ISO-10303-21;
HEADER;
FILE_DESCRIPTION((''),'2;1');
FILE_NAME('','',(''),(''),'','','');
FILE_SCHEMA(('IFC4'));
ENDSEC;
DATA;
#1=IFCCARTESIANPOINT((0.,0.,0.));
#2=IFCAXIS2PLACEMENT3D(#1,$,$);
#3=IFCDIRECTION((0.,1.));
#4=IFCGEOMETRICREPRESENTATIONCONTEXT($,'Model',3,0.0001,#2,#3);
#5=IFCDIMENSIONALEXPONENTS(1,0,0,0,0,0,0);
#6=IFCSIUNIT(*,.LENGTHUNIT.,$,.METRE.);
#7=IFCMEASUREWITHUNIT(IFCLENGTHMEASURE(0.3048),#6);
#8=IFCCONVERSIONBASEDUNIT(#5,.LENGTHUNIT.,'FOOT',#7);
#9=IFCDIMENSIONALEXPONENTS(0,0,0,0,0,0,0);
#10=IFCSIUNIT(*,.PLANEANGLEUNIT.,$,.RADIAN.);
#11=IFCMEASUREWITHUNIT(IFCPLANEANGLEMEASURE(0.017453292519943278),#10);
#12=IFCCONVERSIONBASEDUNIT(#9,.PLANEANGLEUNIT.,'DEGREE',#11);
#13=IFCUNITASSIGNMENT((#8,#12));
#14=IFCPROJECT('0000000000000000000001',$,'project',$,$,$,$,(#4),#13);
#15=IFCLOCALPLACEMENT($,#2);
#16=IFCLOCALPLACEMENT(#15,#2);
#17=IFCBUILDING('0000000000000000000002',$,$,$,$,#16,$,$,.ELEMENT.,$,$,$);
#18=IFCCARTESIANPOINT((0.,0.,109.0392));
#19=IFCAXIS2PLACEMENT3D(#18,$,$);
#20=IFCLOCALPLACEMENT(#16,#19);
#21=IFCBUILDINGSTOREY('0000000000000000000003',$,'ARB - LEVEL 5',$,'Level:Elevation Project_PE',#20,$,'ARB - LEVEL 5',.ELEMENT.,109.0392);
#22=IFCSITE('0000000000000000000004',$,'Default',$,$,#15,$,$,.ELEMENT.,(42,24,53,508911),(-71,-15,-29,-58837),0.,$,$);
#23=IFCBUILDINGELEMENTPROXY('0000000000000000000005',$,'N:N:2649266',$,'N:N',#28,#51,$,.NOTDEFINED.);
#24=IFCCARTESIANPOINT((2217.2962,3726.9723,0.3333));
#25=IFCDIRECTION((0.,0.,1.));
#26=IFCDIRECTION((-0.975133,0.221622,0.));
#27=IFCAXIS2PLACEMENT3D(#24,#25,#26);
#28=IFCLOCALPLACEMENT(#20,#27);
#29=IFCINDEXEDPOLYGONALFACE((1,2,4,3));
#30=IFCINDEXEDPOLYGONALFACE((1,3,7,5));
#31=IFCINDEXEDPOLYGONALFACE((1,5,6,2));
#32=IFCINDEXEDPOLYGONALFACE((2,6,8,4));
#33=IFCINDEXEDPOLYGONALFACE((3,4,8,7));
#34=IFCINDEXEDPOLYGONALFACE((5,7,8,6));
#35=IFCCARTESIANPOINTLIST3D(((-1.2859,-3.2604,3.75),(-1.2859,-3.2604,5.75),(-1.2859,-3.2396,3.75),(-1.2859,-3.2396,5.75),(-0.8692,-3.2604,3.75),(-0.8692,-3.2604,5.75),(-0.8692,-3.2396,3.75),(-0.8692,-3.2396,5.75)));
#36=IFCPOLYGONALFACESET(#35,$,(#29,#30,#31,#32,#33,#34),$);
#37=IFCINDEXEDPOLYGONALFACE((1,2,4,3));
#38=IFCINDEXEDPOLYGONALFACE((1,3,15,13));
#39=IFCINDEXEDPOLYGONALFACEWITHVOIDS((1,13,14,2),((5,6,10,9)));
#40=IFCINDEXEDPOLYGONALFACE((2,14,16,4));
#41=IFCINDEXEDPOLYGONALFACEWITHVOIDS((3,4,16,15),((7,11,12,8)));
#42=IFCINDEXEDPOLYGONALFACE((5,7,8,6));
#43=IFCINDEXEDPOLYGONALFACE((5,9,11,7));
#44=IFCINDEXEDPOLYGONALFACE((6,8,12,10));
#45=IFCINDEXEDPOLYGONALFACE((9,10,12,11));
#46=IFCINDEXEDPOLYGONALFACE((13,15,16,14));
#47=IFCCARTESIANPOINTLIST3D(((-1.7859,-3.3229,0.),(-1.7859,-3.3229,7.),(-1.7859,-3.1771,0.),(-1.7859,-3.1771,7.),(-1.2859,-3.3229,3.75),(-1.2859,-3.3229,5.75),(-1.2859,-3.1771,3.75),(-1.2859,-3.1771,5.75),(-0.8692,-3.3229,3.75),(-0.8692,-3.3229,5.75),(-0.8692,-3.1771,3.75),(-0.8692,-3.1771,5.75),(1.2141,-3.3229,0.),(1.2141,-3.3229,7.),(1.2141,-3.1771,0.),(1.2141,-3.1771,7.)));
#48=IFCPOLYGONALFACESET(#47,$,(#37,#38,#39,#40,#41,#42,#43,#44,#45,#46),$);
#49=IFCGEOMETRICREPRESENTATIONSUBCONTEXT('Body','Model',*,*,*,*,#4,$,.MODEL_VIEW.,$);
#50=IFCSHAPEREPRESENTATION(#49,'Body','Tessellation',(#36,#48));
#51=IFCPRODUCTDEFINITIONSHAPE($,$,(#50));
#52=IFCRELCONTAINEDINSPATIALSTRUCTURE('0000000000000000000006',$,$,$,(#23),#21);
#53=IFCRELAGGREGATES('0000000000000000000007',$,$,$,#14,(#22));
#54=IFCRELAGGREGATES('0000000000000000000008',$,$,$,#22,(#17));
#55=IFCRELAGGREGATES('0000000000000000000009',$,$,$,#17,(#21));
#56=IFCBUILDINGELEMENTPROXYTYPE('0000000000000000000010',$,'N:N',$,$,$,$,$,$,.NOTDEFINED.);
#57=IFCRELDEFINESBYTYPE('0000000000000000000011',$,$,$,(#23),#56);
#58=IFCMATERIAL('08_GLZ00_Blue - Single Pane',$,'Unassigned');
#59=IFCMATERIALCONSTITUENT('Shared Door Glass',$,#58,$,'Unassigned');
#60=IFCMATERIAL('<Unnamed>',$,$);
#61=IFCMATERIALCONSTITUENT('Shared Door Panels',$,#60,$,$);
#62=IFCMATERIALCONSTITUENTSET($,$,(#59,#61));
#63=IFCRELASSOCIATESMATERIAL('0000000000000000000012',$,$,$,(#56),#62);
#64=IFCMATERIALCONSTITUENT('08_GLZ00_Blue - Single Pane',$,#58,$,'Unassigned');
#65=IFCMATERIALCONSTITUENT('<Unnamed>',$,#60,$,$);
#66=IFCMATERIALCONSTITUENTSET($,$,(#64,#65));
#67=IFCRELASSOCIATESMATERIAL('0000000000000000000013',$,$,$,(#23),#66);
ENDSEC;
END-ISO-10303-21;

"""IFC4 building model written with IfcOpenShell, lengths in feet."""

from ifc_helpers import new_model, entity, si_unit, converted_unit, direction, frame, origin, place, context, subcontext, project, spatial, indexed_curve, outline, extrude, source, transform, mapped, material, constituent, constituent_set, type_object, type_shapes, element, save


model = new_model("IFC4")

# Units and contexts
model_context = context("Model", 3, precision=0.0001, world=origin(), true_north=direction((0.0, 1.0)))
body_context = subcontext(model_context, "Body", "Model", "MODEL_VIEW")
ifc_project = project(units=[converted_unit("LENGTHUNIT", "FOOT", entity("IfcLengthMeasure", 0.3048), si_unit("LENGTHUNIT", "METRE"), dimensions=[1, 0, 0, 0, 0, 0, 0]), converted_unit("PLANEANGLEUNIT", "DEGREE", entity("IfcPlaneAngleMeasure", 0.017453292519943278), si_unit("PLANEANGLEUNIT", "RADIAN"), dimensions=[0, 0, 0, 0, 0, 0, 0])], contexts=[model_context])

# Site, building, storey
site_placement = place(None, origin())
site = spatial("IfcSite", under=ifc_project, at=site_placement, Name="Default", CompositionType="ELEMENT", RefLatitude=(42, 24, 53, 508911), RefLongitude=(-71, -15, -29, -58837), RefElevation=0.0)
building_placement = place(site_placement, origin())
building = spatial("IfcBuilding", under=site, at=building_placement, CompositionType="ELEMENT")
storey_placement = place(building_placement, frame((0.0, 0.0, 109.0392)))
storey = spatial("IfcBuildingStorey", under=building, at=storey_placement, Name="ARB - LEVEL 5", ObjectType="Level:Elevation Project_PE", LongName="ARB - LEVEL 5", CompositionType="ELEMENT", Elevation=109.0392)

# Shared definitions
ifc_material_1 = material(Name="<Unnamed>")

# Building element proxy
ifc_material_2 = material(Name="08_GLZ00_Blue - Single Pane", Category="Unassigned")
ifc_constituent_1 = constituent(ifc_material_2, Name="08_GLZ00_Blue - Single Pane", Category="Unassigned")
ifc_constituent_2 = constituent(ifc_material_1, Name="<Unnamed>")
ifc_constituent_set_1 = constituent_set(constituents=[ifc_constituent_1, ifc_constituent_2])
ifc_constituent_3 = constituent(ifc_material_2, Name="Shared Door Glass", Category="Unassigned")
ifc_constituent_4 = constituent(ifc_material_1, Name="Shared Door Panels")
ifc_constituent_set_2 = constituent_set(constituents=[ifc_constituent_3, ifc_constituent_4])
building_element_proxy_type_1 = type_object("IfcBuildingElementProxyType", Name="N:N", PredefinedType="NOTDEFINED", material=ifc_constituent_set_2)
shared_shape_1 = source(origin(), body_context, "Body", "SweptSolid", [
    extrude(outline(indexed_curve([(-0.2083, -0.0104), (0.2083, -0.0104), (0.2083, 0.0104), (-0.2083, 0.0104), (-0.2083, -0.0104)], self_intersect=False)), frame((-1.0775, -3.25, 3.75), z_axis=(0.0, 0.0, 1.0), x_axis=(-1.0, 0.0, 0.0)), (0.0, 0.0, 1.0), 2.0),
    extrude(outline(indexed_curve([(-3.5, -1.5), (3.5, -1.5), (3.5, 1.5), (-3.5, 1.5), (-3.5, -1.5)], self_intersect=False), holes=[indexed_curve([(-2.25, 0.5833), (-2.25, 1.0), (-0.25, 1.0), (-0.25, 0.5833), (-2.25, 0.5833)], self_intersect=False)]), frame((-0.2859, -3.3229, 3.5), z_axis=(0.0, 1.0, 0.0), x_axis=(0.0, 0.0, -1.0)), (0.0, 0.0, 1.0), 0.1458),
])
type_shapes(building_element_proxy_type_1, [shared_shape_1])
proxy_1_placement = place(storey_placement, frame((2217.2962, 3726.9723, 0.3333), z_axis=(0.0, 0.0, 1.0), x_axis=(-0.975133, 0.221622, 0.0)))
element("IfcBuildingElementProxy", 1, at=proxy_1_placement, inside=storey, type_object=building_element_proxy_type_1, material=ifc_constituent_set_1, Name="N:N:2649266", ObjectType="N:N", PredefinedType="NOTDEFINED", context=body_context, shape_type="MappedRepresentation", body=[
    mapped(shared_shape_1, transform((0.0, 0.0, 0.0), scale=1.0)),
])

save(model, "model.ifc")
